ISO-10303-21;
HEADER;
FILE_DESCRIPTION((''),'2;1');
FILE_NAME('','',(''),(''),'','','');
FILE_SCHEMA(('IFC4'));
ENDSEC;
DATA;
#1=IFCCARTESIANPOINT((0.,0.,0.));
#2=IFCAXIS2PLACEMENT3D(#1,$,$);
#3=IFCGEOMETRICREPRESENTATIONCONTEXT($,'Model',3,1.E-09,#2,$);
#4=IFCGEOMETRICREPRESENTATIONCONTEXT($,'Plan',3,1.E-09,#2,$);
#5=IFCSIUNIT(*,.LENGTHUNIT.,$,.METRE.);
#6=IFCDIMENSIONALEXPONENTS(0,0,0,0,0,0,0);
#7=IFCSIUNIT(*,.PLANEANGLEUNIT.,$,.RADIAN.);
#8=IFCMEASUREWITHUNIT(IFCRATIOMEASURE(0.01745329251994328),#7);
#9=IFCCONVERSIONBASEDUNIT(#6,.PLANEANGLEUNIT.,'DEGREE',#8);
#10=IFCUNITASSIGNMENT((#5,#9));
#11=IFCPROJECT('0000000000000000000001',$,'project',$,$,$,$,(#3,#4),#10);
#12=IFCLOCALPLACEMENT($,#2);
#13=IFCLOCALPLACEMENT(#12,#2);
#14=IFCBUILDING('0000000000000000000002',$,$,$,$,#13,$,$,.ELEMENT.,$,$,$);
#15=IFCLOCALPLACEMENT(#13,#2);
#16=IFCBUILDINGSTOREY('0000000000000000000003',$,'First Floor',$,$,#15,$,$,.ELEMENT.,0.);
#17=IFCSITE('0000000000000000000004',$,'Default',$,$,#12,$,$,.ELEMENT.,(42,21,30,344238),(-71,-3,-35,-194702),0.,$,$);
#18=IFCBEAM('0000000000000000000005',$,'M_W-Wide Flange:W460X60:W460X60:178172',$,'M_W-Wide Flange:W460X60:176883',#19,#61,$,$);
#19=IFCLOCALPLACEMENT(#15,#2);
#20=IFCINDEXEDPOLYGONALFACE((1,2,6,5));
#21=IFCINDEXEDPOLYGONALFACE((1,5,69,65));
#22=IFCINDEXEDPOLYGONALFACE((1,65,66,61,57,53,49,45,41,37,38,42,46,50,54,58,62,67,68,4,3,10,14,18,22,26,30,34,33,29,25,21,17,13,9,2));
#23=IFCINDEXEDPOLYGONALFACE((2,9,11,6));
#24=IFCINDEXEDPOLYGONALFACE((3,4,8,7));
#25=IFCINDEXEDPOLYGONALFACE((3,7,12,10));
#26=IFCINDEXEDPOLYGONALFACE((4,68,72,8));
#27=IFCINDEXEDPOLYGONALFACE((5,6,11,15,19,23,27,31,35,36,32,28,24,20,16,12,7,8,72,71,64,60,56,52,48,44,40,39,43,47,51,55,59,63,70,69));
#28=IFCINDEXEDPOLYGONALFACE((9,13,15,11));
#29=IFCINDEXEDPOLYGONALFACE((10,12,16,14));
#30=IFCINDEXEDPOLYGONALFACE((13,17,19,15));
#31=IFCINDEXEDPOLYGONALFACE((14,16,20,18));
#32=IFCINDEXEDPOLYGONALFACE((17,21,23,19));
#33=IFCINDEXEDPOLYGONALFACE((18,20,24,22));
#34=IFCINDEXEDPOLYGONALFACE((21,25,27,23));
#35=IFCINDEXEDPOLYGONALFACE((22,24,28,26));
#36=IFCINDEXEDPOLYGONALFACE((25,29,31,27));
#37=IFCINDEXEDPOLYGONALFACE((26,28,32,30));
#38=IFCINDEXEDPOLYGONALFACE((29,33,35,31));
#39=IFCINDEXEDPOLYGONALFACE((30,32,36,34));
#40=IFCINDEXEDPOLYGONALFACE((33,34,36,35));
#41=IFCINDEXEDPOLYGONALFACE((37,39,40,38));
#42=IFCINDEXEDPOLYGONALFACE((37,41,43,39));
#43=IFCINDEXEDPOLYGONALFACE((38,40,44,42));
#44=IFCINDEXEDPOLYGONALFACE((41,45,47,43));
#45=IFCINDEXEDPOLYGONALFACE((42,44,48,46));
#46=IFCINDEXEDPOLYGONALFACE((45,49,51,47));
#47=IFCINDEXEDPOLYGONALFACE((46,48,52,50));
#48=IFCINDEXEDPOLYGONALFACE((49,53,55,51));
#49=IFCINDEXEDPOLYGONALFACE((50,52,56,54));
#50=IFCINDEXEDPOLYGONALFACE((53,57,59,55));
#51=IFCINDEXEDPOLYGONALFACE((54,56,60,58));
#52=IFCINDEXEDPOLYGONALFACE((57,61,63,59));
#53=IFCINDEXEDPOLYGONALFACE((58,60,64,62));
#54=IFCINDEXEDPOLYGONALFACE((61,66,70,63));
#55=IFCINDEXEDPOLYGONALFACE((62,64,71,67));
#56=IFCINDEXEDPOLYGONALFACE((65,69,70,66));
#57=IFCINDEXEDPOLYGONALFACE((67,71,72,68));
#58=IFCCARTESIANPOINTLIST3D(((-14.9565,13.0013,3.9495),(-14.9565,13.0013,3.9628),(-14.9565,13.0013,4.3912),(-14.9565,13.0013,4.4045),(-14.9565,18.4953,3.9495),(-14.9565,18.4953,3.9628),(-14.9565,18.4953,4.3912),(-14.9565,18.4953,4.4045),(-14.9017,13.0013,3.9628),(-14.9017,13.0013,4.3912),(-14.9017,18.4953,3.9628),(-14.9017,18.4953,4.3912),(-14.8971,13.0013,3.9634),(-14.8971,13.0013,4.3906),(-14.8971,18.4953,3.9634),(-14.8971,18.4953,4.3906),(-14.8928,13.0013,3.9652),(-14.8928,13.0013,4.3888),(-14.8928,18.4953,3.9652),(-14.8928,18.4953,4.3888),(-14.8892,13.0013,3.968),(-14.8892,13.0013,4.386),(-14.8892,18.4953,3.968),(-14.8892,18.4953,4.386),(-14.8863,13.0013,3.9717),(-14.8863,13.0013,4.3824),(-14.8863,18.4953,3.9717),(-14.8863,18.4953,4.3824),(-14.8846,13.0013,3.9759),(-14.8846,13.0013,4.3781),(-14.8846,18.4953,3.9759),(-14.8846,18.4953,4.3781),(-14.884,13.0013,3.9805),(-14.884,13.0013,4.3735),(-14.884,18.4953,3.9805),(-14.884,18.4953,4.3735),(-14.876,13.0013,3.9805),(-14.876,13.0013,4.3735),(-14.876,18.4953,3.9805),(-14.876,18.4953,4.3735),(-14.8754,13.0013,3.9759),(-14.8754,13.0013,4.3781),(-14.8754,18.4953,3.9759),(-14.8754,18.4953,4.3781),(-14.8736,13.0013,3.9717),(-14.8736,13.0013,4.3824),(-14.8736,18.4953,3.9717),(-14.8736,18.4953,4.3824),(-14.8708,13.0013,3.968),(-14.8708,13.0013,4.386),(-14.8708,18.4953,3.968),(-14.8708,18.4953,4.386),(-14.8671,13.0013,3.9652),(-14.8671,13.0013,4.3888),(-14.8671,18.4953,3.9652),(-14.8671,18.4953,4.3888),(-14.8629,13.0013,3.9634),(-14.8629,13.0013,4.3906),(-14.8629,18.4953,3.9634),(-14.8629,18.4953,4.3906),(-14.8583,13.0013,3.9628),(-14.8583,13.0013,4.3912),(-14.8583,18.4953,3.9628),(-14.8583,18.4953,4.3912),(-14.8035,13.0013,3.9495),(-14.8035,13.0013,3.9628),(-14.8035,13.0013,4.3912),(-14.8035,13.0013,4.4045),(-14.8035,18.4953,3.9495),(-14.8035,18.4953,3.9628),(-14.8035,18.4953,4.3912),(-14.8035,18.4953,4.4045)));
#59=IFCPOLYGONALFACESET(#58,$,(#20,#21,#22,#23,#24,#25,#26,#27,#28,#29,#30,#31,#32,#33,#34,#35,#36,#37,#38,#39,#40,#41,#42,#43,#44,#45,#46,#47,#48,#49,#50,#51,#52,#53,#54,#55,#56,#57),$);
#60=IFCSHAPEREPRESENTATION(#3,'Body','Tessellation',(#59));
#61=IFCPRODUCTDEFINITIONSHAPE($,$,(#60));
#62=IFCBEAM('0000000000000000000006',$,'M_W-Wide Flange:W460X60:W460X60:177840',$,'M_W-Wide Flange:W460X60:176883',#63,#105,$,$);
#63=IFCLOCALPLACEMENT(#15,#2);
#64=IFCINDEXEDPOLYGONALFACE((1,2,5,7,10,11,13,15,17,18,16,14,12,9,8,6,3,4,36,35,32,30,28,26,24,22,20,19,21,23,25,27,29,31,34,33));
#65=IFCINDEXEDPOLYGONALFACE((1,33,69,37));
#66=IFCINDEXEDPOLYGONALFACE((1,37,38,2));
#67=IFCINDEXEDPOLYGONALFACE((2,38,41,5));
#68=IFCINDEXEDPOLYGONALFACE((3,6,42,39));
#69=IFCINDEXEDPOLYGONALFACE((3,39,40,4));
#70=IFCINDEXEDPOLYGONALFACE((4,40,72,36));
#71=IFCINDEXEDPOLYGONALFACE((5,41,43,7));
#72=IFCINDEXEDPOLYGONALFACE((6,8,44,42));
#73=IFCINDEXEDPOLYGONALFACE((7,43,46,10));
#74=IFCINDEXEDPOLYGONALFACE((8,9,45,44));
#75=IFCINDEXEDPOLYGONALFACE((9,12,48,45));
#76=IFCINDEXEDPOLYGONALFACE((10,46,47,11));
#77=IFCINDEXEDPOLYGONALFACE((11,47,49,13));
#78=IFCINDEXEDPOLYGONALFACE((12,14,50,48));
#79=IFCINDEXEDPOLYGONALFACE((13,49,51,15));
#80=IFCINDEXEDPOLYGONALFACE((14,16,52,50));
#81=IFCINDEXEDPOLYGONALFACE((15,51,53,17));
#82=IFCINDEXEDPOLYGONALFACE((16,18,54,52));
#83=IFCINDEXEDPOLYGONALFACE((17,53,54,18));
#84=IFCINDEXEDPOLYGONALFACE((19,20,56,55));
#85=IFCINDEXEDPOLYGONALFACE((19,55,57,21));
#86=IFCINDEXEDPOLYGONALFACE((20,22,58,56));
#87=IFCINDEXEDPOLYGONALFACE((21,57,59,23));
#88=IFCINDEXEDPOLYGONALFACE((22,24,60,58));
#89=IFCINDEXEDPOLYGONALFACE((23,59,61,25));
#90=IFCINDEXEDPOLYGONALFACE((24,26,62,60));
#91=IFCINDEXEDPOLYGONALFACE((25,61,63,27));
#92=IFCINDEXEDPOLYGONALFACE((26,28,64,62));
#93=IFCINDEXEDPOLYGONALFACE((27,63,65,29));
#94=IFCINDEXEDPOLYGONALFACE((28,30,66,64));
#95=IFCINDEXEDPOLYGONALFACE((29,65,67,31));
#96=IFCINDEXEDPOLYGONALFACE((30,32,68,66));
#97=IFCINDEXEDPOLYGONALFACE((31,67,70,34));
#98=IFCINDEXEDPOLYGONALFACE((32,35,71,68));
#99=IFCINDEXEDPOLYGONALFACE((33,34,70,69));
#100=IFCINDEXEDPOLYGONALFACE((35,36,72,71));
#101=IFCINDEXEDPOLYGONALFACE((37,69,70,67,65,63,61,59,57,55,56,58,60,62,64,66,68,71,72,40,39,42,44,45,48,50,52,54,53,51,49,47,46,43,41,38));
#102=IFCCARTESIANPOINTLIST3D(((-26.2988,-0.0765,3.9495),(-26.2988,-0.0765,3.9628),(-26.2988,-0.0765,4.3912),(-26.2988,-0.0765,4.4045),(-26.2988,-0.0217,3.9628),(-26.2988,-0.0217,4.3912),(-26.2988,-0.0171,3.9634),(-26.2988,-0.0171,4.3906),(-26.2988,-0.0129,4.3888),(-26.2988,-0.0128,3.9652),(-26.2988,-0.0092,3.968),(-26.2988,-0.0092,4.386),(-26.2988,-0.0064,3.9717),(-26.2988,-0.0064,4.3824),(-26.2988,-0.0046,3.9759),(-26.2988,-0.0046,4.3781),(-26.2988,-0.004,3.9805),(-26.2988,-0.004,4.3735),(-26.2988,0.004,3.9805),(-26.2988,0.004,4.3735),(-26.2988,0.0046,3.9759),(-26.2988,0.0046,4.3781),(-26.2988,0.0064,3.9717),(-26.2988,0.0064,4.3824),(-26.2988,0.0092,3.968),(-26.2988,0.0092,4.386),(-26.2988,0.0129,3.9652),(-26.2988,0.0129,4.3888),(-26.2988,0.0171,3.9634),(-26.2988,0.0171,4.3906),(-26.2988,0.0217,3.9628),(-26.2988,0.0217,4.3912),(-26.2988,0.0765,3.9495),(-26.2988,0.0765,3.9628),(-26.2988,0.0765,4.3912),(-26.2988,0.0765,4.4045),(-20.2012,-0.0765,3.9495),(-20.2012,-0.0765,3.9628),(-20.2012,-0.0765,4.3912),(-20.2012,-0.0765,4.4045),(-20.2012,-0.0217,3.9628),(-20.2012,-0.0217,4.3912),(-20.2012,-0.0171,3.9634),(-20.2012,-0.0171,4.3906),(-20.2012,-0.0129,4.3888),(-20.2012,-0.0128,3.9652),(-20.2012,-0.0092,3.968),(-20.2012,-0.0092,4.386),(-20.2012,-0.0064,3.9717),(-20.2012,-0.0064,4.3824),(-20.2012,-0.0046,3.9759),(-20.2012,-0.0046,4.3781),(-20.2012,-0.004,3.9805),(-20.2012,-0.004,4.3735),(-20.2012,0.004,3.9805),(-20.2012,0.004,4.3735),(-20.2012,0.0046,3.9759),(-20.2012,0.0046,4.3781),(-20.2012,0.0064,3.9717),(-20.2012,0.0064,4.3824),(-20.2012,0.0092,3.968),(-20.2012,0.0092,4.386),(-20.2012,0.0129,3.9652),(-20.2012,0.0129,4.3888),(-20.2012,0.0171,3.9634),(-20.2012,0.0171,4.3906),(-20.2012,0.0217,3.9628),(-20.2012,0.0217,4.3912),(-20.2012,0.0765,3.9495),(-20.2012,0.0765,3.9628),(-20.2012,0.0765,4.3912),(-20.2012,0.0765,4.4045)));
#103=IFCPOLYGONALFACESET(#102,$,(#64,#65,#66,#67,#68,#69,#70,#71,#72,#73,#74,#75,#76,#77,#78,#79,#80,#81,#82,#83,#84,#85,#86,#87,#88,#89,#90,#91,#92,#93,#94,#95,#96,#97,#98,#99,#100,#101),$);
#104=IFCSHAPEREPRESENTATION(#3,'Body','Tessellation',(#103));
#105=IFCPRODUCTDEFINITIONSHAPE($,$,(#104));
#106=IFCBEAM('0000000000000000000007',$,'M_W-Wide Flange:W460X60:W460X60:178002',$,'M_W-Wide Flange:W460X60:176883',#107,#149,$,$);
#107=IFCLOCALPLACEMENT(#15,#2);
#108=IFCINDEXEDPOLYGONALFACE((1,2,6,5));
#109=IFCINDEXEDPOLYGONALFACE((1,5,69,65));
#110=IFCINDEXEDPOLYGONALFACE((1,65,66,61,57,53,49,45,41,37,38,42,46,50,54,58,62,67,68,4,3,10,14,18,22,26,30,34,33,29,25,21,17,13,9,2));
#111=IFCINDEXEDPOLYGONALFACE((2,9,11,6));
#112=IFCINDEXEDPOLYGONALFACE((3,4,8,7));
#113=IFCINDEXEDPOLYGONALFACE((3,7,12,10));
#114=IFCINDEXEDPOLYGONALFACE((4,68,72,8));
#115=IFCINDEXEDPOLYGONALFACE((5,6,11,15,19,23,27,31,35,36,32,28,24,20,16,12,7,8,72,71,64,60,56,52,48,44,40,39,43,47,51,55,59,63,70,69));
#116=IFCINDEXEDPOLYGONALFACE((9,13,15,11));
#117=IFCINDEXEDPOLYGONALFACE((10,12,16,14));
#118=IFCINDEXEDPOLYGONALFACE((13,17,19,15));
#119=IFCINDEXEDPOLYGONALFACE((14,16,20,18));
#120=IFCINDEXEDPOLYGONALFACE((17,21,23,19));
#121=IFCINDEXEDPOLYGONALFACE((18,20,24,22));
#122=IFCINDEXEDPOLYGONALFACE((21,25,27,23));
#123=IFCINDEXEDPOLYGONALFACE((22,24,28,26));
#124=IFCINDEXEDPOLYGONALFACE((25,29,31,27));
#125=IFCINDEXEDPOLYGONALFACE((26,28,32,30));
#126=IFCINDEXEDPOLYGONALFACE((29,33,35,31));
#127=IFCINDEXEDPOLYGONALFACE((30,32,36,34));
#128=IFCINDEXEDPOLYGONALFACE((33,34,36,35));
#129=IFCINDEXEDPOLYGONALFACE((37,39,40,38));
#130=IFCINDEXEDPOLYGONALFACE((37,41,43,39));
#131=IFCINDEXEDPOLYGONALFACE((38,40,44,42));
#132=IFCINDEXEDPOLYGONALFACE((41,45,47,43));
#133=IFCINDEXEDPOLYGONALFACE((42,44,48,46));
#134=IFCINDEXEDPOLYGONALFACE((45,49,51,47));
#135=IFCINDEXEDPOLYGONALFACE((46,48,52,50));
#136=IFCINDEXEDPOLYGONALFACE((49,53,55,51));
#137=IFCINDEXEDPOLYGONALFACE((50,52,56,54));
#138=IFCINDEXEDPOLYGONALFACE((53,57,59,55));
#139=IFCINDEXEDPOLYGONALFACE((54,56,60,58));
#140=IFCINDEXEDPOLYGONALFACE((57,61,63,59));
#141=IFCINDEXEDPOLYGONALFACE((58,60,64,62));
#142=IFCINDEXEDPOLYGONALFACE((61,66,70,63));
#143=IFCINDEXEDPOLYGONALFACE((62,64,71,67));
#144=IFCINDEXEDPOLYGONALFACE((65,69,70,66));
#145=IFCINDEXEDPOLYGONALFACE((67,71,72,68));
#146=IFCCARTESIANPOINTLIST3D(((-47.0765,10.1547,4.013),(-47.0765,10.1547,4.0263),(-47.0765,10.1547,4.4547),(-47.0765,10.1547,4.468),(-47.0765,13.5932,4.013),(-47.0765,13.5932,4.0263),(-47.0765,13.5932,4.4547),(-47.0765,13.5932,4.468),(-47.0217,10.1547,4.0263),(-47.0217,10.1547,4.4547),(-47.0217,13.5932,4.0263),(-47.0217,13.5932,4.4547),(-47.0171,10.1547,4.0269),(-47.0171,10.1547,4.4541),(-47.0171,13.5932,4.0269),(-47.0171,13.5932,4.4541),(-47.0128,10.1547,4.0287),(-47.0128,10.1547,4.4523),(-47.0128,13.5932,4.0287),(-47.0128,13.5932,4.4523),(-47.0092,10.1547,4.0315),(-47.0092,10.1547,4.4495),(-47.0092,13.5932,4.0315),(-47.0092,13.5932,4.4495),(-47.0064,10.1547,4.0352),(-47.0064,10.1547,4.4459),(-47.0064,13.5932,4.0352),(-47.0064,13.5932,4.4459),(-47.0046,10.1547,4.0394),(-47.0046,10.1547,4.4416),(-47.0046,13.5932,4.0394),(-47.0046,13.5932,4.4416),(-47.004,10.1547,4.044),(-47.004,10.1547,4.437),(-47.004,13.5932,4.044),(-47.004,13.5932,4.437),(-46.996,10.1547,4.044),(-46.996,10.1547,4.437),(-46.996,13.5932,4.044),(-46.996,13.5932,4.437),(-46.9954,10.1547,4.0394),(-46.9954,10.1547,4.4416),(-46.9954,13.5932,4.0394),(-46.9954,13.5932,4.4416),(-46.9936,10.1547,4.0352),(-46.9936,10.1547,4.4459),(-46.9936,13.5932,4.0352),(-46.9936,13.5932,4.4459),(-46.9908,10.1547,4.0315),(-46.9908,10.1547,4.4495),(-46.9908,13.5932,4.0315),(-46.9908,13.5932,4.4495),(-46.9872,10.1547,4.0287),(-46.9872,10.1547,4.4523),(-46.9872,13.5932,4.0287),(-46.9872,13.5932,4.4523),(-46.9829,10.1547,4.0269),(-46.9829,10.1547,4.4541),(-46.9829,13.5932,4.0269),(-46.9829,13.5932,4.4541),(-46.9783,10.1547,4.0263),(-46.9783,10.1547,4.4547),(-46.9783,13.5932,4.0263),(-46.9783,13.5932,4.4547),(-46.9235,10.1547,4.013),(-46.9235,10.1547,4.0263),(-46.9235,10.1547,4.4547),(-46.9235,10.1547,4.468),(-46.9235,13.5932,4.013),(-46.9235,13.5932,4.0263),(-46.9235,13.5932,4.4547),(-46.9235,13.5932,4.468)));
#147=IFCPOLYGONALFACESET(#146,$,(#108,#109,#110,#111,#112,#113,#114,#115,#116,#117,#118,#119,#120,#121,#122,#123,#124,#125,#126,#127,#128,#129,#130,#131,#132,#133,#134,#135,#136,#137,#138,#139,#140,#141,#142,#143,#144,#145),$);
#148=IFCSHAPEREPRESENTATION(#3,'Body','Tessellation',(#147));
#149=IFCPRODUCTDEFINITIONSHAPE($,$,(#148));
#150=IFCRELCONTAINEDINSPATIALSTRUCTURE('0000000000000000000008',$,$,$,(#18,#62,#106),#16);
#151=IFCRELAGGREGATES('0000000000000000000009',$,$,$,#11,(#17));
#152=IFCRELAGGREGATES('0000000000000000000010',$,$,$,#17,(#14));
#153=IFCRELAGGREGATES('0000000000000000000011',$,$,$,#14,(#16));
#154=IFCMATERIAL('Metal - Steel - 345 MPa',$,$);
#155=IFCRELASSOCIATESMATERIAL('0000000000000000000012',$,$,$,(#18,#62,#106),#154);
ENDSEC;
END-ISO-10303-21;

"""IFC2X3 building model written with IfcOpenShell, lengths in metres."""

from ifc_helpers import new_model, entity, si_unit, converted_unit, frame, frame_2d, origin, place, context, project, spatial, polyline, circle_curve, parameter, trimmed, segment, composite_curve, outline, extrude, material, element, save


model = new_model("IFC2X3")

# Units and contexts
model_context = context("Model", 3, precision=1e-09, world=origin())
plan_context = context("Plan", 3, precision=1e-09, world=origin())
ifc_project = project(units=[si_unit("LENGTHUNIT", "METRE"), converted_unit("PLANEANGLEUNIT", "DEGREE", entity("IfcRatioMeasure", 0.01745329251994328), si_unit("PLANEANGLEUNIT", "RADIAN"), dimensions=[0, 0, 0, 0, 0, 0, 0])], contexts=[model_context, plan_context])

# Site, building, storey
site_placement = place(None, origin())
site = spatial("IfcSite", under=ifc_project, at=site_placement, Name="Default", CompositionType="ELEMENT", RefLatitude=(42, 21, 30, 344238), RefLongitude=(-71, -3, -35, -194702), RefElevation=0.0)
building_placement = place(site_placement, origin())
building = spatial("IfcBuilding", under=site, at=building_placement, CompositionType="ELEMENT")
storey_placement = place(building_placement, origin())
storey = spatial("IfcBuildingStorey", under=building, at=storey_placement, Name="First Floor", CompositionType="ELEMENT", Elevation=0.0)

# Beams
ifc_material_1 = material(Name="Metal - Steel - 345 MPa")
beam_1_placement = place(storey_placement, frame((-14.88, 10.0384, 4.4045)))
element("IfcBeam", 1, at=beam_1_placement, inside=storey, material=ifc_material_1, Name="M_W-Wide Flange:W460X60:W460X60:178172", ObjectType="M_W-Wide Flange:W460X60:176883", context=model_context, shape_type="SweptSolid", body=[
    extrude(outline(composite_curve([segment(polyline([(-0.0765, -0.2142), (-0.0765, -0.2275)]), True, "CONTINUOUS"), segment(polyline([(-0.0765, -0.2275), (0.0765, -0.2275)]), True, "CONTINUOUS"), segment(polyline([(0.0765, -0.2275), (0.0765, -0.2142)]), True, "CONTINUOUS"), segment(polyline([(0.0765, -0.2142), (0.0217, -0.2142)]), True, "CONTINUOUS"), segment(trimmed(circle_curve(frame_2d((0.0217, -0.1965), x_axis=(1.0, 0.0)), 0.0177), [parameter(180.0)], [parameter(270.0)], True, "PARAMETER"), False, "CONTINUOUS"), segment(polyline([(0.004, -0.1965), (0.004, 0.1965)]), True, "CONTINUOUS"), segment(trimmed(circle_curve(frame_2d((0.0217, 0.1965), x_axis=(1.0, 0.0)), 0.0177), [parameter(90.0)], [parameter(180.0)], True, "PARAMETER"), False, "CONTINUOUS"), segment(polyline([(0.0217, 0.2142), (0.0765, 0.2142)]), True, "CONTINUOUS"), segment(polyline([(0.0765, 0.2142), (0.0765, 0.2275)]), True, "CONTINUOUS"), segment(polyline([(0.0765, 0.2275), (-0.0765, 0.2275)]), True, "CONTINUOUS"), segment(polyline([(-0.0765, 0.2275), (-0.0765, 0.2142)]), True, "CONTINUOUS"), segment(polyline([(-0.0765, 0.2142), (-0.0217, 0.2142)]), True, "CONTINUOUS"), segment(trimmed(circle_curve(frame_2d((-0.0217, 0.1965), x_axis=(1.0, 0.0)), 0.0177), [parameter(360.0)], [parameter(90.0)], True, "PARAMETER"), False, "CONTINUOUS"), segment(polyline([(-0.004, 0.1965), (-0.004, -0.1965)]), True, "CONTINUOUS"), segment(trimmed(circle_curve(frame_2d((-0.0217, -0.1965), x_axis=(1.0, 0.0)), 0.0177), [parameter(270.0)], [parameter(0.0)], True, "PARAMETER"), False, "CONTINUOUS"), segment(polyline([(-0.0217, -0.2142), (-0.0765, -0.2142)]), True, "CONTINUOUS")], self_intersect=False)), frame((0.0, 2.9629, -0.2275), z_axis=(0.0, -1.0, 0.0), x_axis=(1.0, 0.0, 0.0)), (0.0, 0.0, -1.0), 5.494),
])
beam_2_placement = place(storey_placement, frame((-26.4421, 0.0, 4.4045), z_axis=(0.0, 0.0, 1.0), x_axis=(0.0, -1.0, 0.0)))
element("IfcBeam", 2, at=beam_2_placement, inside=storey, material=ifc_material_1, Name="M_W-Wide Flange:W460X60:W460X60:177840", ObjectType="M_W-Wide Flange:W460X60:176883", context=model_context, shape_type="SweptSolid", body=[
    extrude(outline(composite_curve([segment(polyline([(-0.0765, -0.2142), (-0.0765, -0.2275)]), True, "CONTINUOUS"), segment(polyline([(-0.0765, -0.2275), (0.0765, -0.2275)]), True, "CONTINUOUS"), segment(polyline([(0.0765, -0.2275), (0.0765, -0.2142)]), True, "CONTINUOUS"), segment(polyline([(0.0765, -0.2142), (0.0217, -0.2142)]), True, "CONTINUOUS"), segment(trimmed(circle_curve(frame_2d((0.0217, -0.1965), x_axis=(0.0, -1.0)), 0.0177), [parameter(270.0)], [parameter(360.0)], True, "PARAMETER"), False, "CONTINUOUS"), segment(polyline([(0.004, -0.1965), (0.004, 0.1965)]), True, "CONTINUOUS"), segment(trimmed(circle_curve(frame_2d((0.0217, 0.1965), x_axis=(-1.0, 0.0)), 0.0177), [parameter(270.0)], [parameter(360.0)], True, "PARAMETER"), False, "CONTINUOUS"), segment(polyline([(0.0217, 0.2142), (0.0765, 0.2142)]), True, "CONTINUOUS"), segment(polyline([(0.0765, 0.2142), (0.0765, 0.2275)]), True, "CONTINUOUS"), segment(polyline([(0.0765, 0.2275), (-0.0765, 0.2275)]), True, "CONTINUOUS"), segment(polyline([(-0.0765, 0.2275), (-0.0765, 0.2142)]), True, "CONTINUOUS"), segment(polyline([(-0.0765, 0.2142), (-0.0217, 0.2142)]), True, "CONTINUOUS"), segment(trimmed(circle_curve(frame_2d((-0.0217, 0.1965), x_axis=(0.0, 1.0)), 0.0177), [parameter(270.0)], [parameter(360.0)], True, "PARAMETER"), False, "CONTINUOUS"), segment(polyline([(-0.004, 0.1965), (-0.004, -0.1965)]), True, "CONTINUOUS"), segment(trimmed(circle_curve(frame_2d((-0.0217, -0.1965), x_axis=(1.0, 0.0)), 0.0177), [parameter(270.0)], [parameter(0.0)], True, "PARAMETER"), False, "CONTINUOUS"), segment(polyline([(-0.0217, -0.2142), (-0.0765, -0.2142)]), True, "CONTINUOUS")], self_intersect=False)), frame((0.0, 0.1433, -0.2275), z_axis=(0.0, -1.0, 0.0), x_axis=(1.0, 0.0, 0.0)), (0.0, 0.0, -1.0), 6.0976),
])
beam_3_placement = place(storey_placement, frame((-47.0, 10.0363, 4.468)))
element("IfcBeam", 3, at=beam_3_placement, inside=storey, material=ifc_material_1, Name="M_W-Wide Flange:W460X60:W460X60:178002", ObjectType="M_W-Wide Flange:W460X60:176883", context=model_context, shape_type="SweptSolid", body=[
    extrude(outline(composite_curve([segment(polyline([(-0.0765, -0.2142), (-0.0765, -0.2275)]), True, "CONTINUOUS"), segment(polyline([(-0.0765, -0.2275), (0.0765, -0.2275)]), True, "CONTINUOUS"), segment(polyline([(0.0765, -0.2275), (0.0765, -0.2142)]), True, "CONTINUOUS"), segment(polyline([(0.0765, -0.2142), (0.0217, -0.2142)]), True, "CONTINUOUS"), segment(trimmed(circle_curve(frame_2d((0.0217, -0.1965), x_axis=(1.0, 0.0)), 0.0177), [parameter(180.0)], [parameter(270.0)], True, "PARAMETER"), False, "CONTINUOUS"), segment(polyline([(0.004, -0.1965), (0.004, 0.1965)]), True, "CONTINUOUS"), segment(trimmed(circle_curve(frame_2d((0.0217, 0.1965), x_axis=(1.0, 0.0)), 0.0177), [parameter(90.0)], [parameter(180.0)], True, "PARAMETER"), False, "CONTINUOUS"), segment(polyline([(0.0217, 0.2142), (0.0765, 0.2142)]), True, "CONTINUOUS"), segment(polyline([(0.0765, 0.2142), (0.0765, 0.2275)]), True, "CONTINUOUS"), segment(polyline([(0.0765, 0.2275), (-0.0765, 0.2275)]), True, "CONTINUOUS"), segment(polyline([(-0.0765, 0.2275), (-0.0765, 0.2142)]), True, "CONTINUOUS"), segment(polyline([(-0.0765, 0.2142), (-0.0217, 0.2142)]), True, "CONTINUOUS"), segment(trimmed(circle_curve(frame_2d((-0.0217, 0.1965), x_axis=(1.0, 0.0)), 0.0177), [parameter(360.0)], [parameter(90.0)], True, "PARAMETER"), False, "CONTINUOUS"), segment(polyline([(-0.004, 0.1965), (-0.004, -0.1965)]), True, "CONTINUOUS"), segment(trimmed(circle_curve(frame_2d((-0.0217, -0.1965), x_axis=(1.0, 0.0)), 0.0177), [parameter(270.0)], [parameter(0.0)], True, "PARAMETER"), False, "CONTINUOUS"), segment(polyline([(-0.0217, -0.2142), (-0.0765, -0.2142)]), True, "CONTINUOUS")], self_intersect=False)), frame((0.0, 0.1184, -0.2275), z_axis=(0.0, -1.0, 0.0), x_axis=(1.0, 0.0, 0.0)), (0.0, 0.0, -1.0), 3.4385),
])

save(model, "model.ifc")
